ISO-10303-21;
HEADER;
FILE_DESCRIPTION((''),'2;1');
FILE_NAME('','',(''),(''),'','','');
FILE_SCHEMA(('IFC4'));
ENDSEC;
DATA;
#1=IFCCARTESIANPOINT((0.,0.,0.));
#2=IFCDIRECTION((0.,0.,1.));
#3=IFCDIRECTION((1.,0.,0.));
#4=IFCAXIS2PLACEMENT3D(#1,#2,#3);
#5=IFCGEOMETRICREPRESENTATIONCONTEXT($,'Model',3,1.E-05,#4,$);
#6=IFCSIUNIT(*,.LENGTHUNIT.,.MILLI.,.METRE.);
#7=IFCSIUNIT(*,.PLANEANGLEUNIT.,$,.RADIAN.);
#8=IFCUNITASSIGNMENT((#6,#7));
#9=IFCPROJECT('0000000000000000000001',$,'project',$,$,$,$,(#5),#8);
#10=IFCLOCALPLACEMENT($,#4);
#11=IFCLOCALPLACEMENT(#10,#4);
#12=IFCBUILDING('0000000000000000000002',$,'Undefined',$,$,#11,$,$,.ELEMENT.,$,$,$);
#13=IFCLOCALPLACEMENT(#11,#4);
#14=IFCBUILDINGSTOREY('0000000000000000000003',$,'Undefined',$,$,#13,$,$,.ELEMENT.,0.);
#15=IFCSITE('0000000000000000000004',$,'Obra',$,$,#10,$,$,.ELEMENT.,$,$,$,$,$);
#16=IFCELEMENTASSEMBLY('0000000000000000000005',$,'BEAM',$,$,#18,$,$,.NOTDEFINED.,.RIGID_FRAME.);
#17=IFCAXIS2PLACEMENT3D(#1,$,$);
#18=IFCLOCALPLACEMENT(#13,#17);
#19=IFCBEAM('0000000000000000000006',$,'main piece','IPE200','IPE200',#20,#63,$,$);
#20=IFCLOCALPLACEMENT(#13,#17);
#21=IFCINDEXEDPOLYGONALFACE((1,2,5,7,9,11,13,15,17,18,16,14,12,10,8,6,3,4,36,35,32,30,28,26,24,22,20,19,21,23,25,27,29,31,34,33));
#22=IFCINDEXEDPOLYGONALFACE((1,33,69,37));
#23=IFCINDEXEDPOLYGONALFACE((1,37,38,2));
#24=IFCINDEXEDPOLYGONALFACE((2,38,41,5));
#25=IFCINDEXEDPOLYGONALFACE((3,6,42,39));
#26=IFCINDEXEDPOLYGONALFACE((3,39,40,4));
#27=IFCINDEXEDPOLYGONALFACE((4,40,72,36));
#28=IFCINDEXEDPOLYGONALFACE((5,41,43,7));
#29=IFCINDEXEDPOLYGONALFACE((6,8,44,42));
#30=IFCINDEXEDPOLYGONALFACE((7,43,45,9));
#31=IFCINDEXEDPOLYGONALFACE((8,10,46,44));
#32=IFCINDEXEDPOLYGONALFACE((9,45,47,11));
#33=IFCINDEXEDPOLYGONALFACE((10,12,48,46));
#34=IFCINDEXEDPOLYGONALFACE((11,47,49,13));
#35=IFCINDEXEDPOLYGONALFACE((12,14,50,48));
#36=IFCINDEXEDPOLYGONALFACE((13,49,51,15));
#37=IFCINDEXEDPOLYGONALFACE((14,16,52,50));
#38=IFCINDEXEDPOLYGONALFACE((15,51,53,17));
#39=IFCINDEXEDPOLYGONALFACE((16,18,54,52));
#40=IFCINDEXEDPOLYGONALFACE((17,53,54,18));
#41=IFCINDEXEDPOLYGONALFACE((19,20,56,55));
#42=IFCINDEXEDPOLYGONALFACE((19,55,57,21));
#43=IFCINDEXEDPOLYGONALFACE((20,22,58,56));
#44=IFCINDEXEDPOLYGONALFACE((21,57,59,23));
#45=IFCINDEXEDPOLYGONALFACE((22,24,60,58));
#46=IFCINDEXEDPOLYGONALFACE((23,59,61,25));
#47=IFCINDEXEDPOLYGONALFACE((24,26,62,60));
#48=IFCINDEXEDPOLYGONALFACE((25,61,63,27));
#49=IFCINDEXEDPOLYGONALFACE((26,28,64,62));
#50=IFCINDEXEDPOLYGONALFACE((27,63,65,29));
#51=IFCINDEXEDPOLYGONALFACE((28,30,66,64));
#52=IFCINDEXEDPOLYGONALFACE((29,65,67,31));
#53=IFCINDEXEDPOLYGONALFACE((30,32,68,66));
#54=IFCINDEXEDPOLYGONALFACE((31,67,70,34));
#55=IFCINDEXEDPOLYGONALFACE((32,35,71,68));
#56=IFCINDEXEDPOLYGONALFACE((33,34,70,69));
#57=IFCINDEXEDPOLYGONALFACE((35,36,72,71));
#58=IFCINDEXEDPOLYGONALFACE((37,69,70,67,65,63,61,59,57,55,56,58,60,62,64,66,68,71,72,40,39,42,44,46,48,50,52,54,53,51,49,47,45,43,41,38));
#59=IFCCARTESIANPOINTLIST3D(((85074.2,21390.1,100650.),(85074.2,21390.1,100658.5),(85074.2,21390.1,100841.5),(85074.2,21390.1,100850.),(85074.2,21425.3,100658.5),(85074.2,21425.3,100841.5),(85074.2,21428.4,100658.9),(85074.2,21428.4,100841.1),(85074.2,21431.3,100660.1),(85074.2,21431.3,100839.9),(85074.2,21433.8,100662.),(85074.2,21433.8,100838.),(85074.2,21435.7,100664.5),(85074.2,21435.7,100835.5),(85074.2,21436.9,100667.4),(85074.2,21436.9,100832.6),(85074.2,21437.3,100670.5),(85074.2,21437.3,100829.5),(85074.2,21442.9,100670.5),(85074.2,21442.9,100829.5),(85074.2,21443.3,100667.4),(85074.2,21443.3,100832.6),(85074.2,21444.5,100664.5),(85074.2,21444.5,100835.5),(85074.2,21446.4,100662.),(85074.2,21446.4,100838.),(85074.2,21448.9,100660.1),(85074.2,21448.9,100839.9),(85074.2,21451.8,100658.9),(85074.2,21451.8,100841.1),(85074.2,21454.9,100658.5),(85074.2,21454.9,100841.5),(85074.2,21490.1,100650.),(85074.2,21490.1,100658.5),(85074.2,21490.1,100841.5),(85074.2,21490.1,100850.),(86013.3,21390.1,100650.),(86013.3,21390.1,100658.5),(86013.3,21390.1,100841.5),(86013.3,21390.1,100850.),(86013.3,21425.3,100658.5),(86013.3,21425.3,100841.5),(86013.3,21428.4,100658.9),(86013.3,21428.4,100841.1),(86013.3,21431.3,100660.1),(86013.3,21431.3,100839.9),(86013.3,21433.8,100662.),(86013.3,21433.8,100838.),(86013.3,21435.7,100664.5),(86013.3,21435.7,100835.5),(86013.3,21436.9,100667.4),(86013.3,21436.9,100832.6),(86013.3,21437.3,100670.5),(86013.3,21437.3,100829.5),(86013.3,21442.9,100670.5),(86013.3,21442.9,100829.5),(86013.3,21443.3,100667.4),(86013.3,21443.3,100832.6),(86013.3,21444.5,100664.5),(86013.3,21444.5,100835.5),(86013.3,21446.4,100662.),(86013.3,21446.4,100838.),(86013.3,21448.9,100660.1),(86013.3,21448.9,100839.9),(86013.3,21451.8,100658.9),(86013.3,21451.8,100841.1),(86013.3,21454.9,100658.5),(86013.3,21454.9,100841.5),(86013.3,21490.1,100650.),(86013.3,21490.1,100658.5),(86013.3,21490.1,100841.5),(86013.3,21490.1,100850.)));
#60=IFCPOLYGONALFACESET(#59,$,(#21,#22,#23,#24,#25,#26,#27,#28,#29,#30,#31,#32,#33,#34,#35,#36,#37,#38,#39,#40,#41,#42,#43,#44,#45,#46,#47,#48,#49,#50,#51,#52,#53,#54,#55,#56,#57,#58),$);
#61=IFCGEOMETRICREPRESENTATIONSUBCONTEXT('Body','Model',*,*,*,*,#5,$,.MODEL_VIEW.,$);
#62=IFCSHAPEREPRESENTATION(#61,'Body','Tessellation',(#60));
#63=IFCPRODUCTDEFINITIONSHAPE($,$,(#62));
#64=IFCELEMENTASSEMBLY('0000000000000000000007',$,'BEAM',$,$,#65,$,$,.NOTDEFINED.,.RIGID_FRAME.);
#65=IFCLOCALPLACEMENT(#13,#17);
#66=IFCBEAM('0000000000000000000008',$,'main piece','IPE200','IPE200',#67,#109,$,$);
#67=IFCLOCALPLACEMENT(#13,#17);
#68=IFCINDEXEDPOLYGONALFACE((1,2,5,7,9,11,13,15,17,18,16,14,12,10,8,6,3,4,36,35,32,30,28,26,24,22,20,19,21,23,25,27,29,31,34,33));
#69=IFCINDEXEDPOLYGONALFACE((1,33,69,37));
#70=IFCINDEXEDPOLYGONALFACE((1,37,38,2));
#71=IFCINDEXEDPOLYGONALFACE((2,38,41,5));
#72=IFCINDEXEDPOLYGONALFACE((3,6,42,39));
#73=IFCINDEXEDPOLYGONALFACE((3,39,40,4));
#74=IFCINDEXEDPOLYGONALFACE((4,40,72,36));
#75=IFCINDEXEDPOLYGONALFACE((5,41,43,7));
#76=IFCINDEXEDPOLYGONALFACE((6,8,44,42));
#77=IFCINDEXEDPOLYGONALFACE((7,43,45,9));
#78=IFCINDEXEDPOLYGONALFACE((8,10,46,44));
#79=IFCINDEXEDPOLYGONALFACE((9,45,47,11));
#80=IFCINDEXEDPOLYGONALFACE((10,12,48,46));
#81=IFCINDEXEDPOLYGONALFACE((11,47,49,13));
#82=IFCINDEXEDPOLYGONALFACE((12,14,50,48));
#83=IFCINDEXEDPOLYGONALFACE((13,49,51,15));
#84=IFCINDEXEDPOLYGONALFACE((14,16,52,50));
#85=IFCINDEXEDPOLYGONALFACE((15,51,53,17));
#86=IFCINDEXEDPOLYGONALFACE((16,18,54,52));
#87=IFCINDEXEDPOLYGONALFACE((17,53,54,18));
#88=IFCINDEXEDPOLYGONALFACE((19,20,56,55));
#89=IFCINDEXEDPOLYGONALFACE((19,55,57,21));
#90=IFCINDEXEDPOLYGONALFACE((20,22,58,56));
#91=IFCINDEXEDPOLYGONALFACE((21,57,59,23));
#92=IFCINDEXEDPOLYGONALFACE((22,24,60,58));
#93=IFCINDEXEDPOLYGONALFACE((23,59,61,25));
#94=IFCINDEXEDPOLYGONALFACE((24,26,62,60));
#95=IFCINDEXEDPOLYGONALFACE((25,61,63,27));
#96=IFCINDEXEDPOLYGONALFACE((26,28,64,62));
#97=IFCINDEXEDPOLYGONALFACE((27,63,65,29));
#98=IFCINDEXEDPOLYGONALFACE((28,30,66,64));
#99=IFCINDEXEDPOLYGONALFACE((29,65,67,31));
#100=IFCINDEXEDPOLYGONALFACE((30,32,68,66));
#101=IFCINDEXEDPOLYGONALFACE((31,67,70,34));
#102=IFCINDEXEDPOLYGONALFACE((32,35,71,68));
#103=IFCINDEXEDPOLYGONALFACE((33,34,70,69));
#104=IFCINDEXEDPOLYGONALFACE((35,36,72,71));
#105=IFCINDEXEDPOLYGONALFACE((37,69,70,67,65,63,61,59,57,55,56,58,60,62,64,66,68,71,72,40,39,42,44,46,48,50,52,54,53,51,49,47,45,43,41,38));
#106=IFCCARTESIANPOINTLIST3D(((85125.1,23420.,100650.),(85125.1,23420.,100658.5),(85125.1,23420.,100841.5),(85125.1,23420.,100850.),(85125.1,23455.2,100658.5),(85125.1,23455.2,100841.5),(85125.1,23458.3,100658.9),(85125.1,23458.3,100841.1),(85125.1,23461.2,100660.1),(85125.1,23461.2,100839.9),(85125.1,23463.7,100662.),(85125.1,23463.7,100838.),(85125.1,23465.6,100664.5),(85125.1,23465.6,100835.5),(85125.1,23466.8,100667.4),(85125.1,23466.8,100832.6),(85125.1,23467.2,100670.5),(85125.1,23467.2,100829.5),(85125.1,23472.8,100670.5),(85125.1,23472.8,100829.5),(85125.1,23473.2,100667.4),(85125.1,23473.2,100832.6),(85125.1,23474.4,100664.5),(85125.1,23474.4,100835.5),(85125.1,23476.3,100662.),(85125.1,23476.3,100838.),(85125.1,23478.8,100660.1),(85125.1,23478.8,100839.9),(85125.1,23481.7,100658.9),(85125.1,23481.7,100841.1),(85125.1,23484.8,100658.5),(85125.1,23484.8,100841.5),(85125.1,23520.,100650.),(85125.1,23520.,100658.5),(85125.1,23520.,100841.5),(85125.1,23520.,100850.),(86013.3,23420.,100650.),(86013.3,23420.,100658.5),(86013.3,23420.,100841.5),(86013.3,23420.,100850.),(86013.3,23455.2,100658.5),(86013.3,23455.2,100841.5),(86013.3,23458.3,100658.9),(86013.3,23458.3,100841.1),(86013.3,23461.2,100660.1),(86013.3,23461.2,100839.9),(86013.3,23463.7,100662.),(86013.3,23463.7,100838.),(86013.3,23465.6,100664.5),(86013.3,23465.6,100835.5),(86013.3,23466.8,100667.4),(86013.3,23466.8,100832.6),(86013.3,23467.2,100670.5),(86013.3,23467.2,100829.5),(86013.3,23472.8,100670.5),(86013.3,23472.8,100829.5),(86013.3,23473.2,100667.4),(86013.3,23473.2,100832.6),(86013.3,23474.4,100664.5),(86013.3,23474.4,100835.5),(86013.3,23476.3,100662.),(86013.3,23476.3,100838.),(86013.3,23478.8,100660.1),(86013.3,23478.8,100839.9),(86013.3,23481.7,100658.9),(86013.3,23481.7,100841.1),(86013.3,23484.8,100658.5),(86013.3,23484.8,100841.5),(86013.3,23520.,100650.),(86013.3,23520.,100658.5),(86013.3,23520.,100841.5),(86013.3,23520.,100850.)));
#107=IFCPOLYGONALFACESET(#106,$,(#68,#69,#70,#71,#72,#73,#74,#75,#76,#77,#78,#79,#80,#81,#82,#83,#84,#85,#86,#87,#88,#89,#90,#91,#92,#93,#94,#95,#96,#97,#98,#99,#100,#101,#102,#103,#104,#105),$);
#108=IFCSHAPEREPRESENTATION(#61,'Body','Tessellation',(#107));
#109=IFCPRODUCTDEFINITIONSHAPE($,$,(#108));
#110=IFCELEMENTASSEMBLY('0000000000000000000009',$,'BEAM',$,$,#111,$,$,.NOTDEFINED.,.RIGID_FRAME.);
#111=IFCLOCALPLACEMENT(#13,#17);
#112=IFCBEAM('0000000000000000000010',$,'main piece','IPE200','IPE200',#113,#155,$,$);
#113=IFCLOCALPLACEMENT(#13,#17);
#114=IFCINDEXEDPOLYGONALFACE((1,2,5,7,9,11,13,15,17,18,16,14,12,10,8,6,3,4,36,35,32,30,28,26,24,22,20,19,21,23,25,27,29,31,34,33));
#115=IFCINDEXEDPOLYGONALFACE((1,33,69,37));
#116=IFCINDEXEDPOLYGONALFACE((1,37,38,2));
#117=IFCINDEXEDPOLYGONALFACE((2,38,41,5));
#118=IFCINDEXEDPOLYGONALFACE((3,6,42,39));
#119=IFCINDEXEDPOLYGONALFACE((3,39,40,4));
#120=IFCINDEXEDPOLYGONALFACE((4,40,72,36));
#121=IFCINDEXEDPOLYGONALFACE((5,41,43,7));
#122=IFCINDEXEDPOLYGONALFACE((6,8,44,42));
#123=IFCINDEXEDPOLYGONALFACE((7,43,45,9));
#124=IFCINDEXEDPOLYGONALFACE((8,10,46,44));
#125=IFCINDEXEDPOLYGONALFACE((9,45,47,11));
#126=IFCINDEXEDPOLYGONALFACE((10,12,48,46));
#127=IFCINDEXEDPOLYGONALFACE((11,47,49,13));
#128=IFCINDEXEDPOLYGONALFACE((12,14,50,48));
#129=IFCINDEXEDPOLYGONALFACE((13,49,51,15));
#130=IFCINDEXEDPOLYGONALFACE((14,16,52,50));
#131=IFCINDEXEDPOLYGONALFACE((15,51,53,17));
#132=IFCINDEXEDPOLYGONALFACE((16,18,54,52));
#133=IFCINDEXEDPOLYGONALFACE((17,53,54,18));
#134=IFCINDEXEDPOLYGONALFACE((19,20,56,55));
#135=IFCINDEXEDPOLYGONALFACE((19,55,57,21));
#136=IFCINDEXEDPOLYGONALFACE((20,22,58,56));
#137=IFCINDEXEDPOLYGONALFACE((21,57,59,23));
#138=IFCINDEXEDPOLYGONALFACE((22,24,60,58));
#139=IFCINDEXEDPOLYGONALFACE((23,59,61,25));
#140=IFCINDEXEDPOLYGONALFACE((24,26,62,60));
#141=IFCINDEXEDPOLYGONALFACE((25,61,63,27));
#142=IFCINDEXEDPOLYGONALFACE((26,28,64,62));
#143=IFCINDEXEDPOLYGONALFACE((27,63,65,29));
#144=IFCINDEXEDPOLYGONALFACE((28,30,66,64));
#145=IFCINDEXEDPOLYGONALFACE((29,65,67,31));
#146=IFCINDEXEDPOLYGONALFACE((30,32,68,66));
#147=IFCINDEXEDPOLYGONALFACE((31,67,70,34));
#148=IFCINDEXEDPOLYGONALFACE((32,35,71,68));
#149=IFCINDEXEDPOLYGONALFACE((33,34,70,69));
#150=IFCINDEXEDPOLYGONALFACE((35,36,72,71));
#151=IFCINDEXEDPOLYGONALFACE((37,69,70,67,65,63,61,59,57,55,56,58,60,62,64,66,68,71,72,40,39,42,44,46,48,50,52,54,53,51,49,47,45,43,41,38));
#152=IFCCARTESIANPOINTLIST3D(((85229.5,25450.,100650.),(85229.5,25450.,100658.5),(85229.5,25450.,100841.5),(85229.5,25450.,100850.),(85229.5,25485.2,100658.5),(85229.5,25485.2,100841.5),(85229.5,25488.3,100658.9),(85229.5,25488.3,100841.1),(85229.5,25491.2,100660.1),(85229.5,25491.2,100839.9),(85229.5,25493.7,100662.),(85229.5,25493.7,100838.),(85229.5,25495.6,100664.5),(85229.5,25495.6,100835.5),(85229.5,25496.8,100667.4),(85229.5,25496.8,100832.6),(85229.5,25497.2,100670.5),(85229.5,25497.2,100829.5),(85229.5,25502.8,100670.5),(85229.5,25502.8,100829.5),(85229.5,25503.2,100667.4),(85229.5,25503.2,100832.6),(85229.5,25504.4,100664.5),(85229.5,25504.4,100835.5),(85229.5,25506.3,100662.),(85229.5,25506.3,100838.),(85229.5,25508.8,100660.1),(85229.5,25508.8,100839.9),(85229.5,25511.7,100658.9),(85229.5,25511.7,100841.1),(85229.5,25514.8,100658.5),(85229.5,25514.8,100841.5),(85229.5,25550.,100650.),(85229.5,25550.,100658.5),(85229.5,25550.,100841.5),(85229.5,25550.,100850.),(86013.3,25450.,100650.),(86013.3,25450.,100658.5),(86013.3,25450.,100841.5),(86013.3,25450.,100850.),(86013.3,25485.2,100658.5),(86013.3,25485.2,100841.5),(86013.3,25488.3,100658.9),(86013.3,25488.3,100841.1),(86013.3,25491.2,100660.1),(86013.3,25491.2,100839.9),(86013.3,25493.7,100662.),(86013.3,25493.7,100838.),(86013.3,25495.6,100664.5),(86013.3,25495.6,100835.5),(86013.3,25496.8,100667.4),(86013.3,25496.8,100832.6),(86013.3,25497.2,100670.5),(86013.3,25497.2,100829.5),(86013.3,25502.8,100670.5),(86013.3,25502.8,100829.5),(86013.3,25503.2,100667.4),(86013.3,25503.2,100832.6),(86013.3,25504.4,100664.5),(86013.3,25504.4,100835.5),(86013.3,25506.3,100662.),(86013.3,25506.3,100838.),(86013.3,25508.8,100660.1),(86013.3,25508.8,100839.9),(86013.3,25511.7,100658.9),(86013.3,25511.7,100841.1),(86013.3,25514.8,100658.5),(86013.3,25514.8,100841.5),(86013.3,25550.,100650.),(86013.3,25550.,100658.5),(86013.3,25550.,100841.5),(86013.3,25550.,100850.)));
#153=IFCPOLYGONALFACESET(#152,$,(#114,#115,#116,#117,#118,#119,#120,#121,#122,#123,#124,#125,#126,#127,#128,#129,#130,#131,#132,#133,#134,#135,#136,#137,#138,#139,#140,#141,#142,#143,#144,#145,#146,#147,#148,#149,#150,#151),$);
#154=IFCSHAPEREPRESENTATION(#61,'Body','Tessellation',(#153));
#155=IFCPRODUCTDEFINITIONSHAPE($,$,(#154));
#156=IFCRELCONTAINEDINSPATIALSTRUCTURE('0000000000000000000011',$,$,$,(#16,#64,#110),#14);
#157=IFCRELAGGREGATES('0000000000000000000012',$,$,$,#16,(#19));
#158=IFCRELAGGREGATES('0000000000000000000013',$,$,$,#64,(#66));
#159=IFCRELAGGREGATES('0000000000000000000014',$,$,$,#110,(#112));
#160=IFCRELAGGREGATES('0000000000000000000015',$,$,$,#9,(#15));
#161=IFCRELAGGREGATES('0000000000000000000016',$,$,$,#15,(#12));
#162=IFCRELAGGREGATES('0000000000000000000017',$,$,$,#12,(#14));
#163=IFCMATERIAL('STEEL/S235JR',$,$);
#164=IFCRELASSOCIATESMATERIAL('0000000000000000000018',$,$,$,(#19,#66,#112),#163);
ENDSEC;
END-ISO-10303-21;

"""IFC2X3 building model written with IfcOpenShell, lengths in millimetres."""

from ifc_helpers import new_model, si_unit, frame, origin_with_axes, origin_2d_with_axis, place, context, subcontext, project, spatial, i_section, extrude, material, element, aggregate, save


model = new_model("IFC2X3")

# Units and contexts
model_context = context("Model", 3, precision=1e-05, world=origin_with_axes())
body_context = subcontext(model_context, "Body", "Model", "MODEL_VIEW")
ifc_project = project(units=[si_unit("LENGTHUNIT", "METRE", prefix="MILLI"), si_unit("PLANEANGLEUNIT", "RADIAN")], contexts=[model_context])

# Site, building, storey
site_placement = place(None, origin_with_axes())
site = spatial("IfcSite", under=ifc_project, at=site_placement, Name="Obra", CompositionType="ELEMENT")
building_placement = place(site_placement, origin_with_axes())
building = spatial("IfcBuilding", under=site, at=building_placement, Name="Undefined", CompositionType="ELEMENT")
storey_placement = place(building_placement, origin_with_axes())
storey = spatial("IfcBuildingStorey", under=building, at=storey_placement, Name="Undefined", CompositionType="ELEMENT", Elevation=0.0)

# Element assemblies, beams
ifc_material = material(Name="STEEL/S235JR")
assembly_1_placement = place(storey_placement, origin_with_axes())
assembly_1 = element("IfcElementAssembly", 1, at=assembly_1_placement, inside=storey, Name="BEAM", AssemblyPlace="NOTDEFINED", PredefinedType="RIGID_FRAME")
beam_1_placement = place(assembly_1_placement, frame((85074.2, 21440.1, 100750.0), z_axis=(0.0, 0.0, 1.0), x_axis=(1.0, 0.0, 0.0)))
beam_1 = element("IfcBeam", 2, at=beam_1_placement, material=ifc_material, Name="main piece", Description="IPE200", ObjectType="IPE200", context=body_context, shape_type="SweptSolid", body=[
    extrude(i_section(OverallWidth=100.0, OverallDepth=200.0, WebThickness=5.6, FlangeThickness=8.5, FilletRadius=12.0, at=origin_2d_with_axis()), frame((939.1, 0.0, 0.0), z_axis=(-1.0, 0.0, 0.0), x_axis=(0.0, -1.0, 0.0)), (0.0, 0.0, 1.0), 939.1),
])
aggregate(assembly_1, [beam_1])
assembly_2_placement = place(storey_placement, origin_with_axes())
assembly_2 = element("IfcElementAssembly", 3, at=assembly_2_placement, inside=storey, Name="BEAM", AssemblyPlace="NOTDEFINED", PredefinedType="RIGID_FRAME")
beam_2_placement = place(assembly_2_placement, frame((85125.0, 23470.0, 100750.0), z_axis=(0.0, 0.0, 1.0), x_axis=(1.0, 0.0, 0.0)))
beam_2 = element("IfcBeam", 4, at=beam_2_placement, material=ifc_material, Name="main piece", Description="IPE200", ObjectType="IPE200", context=body_context, shape_type="SweptSolid", body=[
    extrude(i_section(OverallWidth=100.0, OverallDepth=200.0, WebThickness=5.6, FlangeThickness=8.5, FilletRadius=12.0, at=origin_2d_with_axis()), frame((888.3, 0.0, 0.0), z_axis=(-1.0, 0.0, 0.0), x_axis=(0.0, -1.0, 0.0)), (0.0, 0.0, 1.0), 888.2),
])
aggregate(assembly_2, [beam_2])
assembly_3_placement = place(storey_placement, origin_with_axes())
assembly_3 = element("IfcElementAssembly", 5, at=assembly_3_placement, inside=storey, Name="BEAM", AssemblyPlace="NOTDEFINED", PredefinedType="RIGID_FRAME")
beam_3_placement = place(assembly_3_placement, frame((85229.5, 25500.0, 100750.0), z_axis=(0.0, 0.0, 1.0), x_axis=(1.0, 0.0, 0.0)))
beam_3 = element("IfcBeam", 6, at=beam_3_placement, material=ifc_material, Name="main piece", Description="IPE200", ObjectType="IPE200", context=body_context, shape_type="SweptSolid", body=[
    extrude(i_section(OverallWidth=100.0, OverallDepth=200.0, WebThickness=5.6, FlangeThickness=8.5, FilletRadius=12.0, at=origin_2d_with_axis()), frame((783.8, 0.0, 0.0), z_axis=(-1.0, 0.0, 0.0), x_axis=(0.0, -1.0, 0.0)), (0.0, 0.0, 1.0), 783.8),
])
aggregate(assembly_3, [beam_3])

save(model, "model.ifc")
